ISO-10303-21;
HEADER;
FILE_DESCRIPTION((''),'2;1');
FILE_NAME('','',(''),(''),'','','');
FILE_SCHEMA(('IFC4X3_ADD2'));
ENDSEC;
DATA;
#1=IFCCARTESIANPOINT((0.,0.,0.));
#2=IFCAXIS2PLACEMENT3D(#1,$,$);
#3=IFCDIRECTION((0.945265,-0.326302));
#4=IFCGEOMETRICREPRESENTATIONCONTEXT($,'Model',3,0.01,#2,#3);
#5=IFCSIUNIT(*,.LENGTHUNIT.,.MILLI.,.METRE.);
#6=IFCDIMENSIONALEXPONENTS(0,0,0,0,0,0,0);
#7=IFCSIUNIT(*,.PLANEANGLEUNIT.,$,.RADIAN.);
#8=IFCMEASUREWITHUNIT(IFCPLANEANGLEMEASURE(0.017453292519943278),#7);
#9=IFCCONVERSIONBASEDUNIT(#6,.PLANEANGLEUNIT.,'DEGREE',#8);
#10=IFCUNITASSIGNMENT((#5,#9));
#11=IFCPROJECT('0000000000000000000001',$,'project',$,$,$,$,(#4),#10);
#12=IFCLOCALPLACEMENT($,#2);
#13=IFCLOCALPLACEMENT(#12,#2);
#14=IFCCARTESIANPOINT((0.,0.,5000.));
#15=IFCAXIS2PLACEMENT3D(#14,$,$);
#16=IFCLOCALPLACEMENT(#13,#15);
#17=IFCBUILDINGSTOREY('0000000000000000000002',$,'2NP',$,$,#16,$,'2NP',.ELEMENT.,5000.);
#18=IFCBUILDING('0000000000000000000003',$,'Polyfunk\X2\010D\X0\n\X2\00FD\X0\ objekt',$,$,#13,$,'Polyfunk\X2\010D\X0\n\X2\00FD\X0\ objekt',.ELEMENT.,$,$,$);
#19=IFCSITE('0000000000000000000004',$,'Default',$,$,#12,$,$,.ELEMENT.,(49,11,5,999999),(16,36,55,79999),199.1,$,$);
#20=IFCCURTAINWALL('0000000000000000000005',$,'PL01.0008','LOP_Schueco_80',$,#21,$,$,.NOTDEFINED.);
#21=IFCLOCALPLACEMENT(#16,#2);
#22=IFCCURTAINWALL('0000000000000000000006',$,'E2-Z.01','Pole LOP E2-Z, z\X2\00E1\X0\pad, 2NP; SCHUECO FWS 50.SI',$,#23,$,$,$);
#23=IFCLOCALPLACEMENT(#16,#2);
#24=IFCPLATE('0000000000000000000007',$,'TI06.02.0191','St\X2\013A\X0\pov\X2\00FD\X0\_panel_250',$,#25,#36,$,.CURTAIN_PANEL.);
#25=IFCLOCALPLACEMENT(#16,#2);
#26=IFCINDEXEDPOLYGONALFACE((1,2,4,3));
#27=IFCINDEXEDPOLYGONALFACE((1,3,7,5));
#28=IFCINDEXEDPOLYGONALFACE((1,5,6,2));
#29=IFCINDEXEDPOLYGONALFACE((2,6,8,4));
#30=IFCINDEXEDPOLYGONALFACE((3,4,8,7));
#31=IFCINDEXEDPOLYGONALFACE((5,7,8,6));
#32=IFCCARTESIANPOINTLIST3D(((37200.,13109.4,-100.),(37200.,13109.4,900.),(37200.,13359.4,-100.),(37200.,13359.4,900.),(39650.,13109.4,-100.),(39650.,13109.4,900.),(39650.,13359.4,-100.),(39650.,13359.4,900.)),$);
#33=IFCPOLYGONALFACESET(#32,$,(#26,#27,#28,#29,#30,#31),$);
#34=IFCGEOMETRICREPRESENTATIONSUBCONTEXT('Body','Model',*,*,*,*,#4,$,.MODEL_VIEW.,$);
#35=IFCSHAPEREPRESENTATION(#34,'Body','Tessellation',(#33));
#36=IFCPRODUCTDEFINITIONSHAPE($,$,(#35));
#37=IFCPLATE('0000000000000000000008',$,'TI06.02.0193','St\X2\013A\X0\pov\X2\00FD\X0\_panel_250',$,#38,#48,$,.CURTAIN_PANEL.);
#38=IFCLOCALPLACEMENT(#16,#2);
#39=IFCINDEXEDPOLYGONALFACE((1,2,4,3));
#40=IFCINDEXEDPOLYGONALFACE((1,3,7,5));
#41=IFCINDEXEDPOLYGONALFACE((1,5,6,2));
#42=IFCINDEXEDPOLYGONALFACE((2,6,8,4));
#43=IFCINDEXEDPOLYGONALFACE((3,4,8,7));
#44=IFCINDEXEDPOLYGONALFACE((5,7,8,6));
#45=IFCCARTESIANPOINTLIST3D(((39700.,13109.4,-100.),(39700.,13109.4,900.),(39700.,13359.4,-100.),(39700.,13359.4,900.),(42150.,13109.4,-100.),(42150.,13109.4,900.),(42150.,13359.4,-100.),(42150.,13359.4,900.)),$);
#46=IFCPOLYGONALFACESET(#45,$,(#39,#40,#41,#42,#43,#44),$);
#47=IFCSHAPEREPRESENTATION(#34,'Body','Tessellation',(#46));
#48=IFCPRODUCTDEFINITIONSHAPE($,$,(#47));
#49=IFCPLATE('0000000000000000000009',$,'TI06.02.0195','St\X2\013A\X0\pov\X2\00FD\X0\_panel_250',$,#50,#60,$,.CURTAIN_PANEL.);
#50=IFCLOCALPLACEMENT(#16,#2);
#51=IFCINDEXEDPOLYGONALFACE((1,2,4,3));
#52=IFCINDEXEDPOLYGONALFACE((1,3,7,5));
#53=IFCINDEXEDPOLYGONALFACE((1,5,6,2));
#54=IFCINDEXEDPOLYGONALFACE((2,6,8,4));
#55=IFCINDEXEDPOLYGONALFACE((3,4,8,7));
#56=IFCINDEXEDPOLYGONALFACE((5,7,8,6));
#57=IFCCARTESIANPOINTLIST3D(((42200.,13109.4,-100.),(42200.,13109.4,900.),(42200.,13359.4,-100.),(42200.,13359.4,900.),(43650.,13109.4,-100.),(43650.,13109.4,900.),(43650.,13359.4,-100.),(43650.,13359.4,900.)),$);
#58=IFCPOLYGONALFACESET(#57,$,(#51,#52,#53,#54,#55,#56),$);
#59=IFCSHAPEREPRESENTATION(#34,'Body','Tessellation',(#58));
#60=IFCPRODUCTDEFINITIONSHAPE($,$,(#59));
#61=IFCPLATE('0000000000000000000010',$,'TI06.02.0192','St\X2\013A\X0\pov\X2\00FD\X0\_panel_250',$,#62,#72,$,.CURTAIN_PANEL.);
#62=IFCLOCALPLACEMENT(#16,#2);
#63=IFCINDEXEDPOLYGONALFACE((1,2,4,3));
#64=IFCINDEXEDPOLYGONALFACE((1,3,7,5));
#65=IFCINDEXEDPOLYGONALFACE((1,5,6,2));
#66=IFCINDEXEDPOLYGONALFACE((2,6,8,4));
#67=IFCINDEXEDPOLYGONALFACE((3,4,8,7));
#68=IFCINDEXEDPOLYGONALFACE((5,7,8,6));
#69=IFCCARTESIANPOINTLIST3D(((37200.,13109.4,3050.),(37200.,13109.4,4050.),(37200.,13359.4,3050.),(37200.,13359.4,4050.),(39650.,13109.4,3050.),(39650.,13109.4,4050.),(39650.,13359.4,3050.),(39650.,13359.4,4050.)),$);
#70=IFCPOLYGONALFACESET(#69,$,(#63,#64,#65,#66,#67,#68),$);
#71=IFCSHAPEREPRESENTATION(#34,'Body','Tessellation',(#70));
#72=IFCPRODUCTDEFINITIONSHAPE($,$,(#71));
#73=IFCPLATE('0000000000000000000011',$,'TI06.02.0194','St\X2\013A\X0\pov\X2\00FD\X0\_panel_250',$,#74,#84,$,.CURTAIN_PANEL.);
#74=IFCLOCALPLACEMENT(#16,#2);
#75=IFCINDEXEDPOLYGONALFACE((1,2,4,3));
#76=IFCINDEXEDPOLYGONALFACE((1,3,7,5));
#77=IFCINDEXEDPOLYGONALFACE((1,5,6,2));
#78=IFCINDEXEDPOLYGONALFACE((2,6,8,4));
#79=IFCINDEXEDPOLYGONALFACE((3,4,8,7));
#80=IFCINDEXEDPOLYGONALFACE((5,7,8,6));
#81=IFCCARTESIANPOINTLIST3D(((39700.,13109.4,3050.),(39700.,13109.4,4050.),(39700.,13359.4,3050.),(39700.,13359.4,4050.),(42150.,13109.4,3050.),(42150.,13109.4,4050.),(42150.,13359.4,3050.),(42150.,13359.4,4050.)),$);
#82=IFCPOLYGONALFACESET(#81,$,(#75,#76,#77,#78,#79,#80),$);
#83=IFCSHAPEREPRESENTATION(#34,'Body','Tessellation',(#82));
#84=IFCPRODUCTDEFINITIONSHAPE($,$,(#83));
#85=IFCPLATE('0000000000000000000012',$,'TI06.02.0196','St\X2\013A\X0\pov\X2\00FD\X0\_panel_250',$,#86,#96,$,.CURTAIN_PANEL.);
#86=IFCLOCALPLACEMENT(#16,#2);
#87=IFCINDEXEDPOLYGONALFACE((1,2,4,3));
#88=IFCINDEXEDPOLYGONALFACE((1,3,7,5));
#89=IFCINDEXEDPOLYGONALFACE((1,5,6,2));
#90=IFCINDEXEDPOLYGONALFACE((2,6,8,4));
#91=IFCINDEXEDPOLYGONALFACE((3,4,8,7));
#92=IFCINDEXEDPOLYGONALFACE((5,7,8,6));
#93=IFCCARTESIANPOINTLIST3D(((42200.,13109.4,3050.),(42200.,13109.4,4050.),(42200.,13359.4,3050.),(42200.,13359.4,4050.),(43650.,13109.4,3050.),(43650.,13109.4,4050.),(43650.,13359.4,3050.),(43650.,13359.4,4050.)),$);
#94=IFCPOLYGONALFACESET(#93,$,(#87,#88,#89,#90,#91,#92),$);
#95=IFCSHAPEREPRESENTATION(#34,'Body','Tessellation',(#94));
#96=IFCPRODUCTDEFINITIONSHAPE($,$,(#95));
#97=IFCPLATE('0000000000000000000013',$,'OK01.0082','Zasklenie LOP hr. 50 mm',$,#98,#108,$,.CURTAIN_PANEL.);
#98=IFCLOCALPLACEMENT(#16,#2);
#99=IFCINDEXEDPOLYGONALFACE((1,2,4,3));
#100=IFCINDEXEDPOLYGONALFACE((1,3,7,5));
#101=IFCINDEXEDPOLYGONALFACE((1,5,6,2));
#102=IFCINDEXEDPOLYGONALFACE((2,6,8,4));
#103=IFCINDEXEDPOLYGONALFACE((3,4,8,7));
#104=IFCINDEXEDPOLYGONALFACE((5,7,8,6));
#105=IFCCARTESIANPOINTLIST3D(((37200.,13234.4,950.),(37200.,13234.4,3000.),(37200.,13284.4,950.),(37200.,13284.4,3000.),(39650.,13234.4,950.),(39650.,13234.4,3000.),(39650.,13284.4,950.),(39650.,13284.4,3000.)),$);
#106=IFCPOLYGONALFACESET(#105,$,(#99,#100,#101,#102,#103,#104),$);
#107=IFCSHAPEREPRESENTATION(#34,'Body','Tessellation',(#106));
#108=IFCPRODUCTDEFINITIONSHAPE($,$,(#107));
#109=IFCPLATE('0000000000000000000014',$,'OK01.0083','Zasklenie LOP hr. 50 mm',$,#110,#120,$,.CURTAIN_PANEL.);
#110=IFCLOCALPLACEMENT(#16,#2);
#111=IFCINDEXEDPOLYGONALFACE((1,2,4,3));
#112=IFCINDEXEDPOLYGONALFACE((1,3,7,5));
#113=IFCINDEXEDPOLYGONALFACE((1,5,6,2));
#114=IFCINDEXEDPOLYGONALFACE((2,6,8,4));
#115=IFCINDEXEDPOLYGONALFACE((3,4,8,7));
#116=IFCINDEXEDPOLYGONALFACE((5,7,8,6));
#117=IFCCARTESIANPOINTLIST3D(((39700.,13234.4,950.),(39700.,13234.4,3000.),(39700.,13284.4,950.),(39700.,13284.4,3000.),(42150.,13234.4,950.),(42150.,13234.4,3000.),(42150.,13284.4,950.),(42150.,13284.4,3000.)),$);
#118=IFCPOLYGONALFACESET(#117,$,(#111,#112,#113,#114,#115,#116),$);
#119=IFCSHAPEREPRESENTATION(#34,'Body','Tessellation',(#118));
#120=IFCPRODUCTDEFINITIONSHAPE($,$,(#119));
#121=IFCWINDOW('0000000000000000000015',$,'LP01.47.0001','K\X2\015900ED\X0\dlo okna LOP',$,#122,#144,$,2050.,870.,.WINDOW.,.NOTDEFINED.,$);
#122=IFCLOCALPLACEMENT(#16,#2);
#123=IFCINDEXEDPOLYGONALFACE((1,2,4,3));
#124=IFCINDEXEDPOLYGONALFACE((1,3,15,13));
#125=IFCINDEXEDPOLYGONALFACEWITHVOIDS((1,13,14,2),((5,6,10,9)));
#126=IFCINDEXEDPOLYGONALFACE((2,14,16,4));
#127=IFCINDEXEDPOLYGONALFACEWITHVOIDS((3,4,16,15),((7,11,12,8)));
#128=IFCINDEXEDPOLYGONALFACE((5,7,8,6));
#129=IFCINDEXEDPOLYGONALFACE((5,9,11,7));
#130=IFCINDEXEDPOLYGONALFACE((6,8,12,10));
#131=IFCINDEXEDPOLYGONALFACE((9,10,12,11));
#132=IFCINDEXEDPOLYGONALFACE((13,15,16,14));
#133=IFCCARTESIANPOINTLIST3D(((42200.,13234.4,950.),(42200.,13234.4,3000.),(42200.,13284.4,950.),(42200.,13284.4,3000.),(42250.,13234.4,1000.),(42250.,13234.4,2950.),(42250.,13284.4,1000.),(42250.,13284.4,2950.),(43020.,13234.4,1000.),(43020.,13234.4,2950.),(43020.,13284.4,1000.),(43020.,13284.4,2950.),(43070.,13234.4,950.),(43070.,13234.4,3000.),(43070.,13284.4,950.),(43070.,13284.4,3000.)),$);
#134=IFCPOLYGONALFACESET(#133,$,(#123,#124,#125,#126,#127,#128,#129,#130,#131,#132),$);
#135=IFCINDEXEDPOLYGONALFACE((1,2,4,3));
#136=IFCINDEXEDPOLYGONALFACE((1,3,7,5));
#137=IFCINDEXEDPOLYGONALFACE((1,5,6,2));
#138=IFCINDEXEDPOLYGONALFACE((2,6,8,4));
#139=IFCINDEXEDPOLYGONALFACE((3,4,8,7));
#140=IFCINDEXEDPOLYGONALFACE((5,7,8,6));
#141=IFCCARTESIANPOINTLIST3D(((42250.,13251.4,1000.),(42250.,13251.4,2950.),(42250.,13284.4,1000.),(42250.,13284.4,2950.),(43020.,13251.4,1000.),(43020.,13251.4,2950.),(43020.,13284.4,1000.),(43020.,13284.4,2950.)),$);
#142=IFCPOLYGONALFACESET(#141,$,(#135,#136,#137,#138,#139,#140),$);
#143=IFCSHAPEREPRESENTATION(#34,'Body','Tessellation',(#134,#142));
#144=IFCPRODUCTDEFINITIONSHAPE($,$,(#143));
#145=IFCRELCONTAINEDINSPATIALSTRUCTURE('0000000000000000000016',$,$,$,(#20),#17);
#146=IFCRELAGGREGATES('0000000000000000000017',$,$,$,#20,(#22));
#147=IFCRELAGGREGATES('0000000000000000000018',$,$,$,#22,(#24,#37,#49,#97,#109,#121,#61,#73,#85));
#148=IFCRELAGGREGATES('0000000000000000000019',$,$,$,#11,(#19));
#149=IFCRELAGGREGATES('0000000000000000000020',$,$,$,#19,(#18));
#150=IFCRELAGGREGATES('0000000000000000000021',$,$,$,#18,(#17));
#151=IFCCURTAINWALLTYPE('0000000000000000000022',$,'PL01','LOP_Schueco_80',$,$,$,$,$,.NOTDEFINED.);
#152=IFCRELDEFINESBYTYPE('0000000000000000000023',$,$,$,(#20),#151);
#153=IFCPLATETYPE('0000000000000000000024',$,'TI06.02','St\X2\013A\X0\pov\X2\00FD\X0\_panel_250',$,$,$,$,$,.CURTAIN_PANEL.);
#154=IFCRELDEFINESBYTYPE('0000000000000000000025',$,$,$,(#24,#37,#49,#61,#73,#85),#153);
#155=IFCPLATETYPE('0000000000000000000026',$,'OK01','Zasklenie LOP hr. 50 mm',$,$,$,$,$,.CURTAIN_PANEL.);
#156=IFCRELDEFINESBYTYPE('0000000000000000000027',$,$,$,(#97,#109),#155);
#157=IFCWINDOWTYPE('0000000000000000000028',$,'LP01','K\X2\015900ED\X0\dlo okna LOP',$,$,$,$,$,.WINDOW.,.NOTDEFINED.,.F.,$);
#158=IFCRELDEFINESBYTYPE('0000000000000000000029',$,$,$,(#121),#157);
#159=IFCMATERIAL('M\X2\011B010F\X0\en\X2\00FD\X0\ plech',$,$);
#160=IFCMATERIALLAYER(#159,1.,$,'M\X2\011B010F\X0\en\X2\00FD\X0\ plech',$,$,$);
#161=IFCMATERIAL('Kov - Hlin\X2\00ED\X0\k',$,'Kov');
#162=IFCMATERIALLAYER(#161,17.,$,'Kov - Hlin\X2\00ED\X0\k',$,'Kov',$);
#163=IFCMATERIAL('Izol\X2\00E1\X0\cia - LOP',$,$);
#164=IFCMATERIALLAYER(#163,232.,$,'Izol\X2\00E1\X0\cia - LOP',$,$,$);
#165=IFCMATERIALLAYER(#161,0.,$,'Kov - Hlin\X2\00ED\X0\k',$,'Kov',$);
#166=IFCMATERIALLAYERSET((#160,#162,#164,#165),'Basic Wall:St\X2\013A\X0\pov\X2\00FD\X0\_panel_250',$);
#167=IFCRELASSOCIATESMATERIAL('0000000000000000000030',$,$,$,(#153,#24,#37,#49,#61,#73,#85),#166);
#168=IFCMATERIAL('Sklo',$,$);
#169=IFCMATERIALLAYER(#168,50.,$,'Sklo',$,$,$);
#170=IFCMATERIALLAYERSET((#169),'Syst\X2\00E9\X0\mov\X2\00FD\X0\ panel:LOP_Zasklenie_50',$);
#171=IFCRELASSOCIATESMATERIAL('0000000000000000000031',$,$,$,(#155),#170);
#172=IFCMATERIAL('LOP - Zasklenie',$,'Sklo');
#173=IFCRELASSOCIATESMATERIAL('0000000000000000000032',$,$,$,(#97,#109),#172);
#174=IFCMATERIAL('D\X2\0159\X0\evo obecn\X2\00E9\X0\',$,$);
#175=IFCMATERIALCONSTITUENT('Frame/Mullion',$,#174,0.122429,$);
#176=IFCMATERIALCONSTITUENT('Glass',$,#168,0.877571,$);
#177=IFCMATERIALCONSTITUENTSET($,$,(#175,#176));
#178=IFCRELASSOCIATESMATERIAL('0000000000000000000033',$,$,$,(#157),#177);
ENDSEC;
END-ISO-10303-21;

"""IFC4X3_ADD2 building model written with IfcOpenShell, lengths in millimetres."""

from ifc_helpers import new_model, entity, si_unit, converted_unit, direction, frame, frame_2d, origin, origin_2d_with_axis, place, context, subcontext, project, spatial, polyline, rectangle, outline, extrude, source, transform, mapped, material, layer, layer_set, layer_usage, constituent, constituent_set, type_object, type_shapes, element, aggregate, save


model = new_model("IFC4X3_ADD2")

# Units and contexts
model_context = context("Model", 3, precision=0.01, world=origin(), true_north=direction((0.945265, -0.326302)))
body_context = subcontext(model_context, "Body", "Model", "MODEL_VIEW")
ifc_project = project(units=[si_unit("LENGTHUNIT", "METRE", prefix="MILLI"), converted_unit("PLANEANGLEUNIT", "DEGREE", entity("IfcPlaneAngleMeasure", 0.017453292519943278), si_unit("PLANEANGLEUNIT", "RADIAN"), dimensions=[0, 0, 0, 0, 0, 0, 0])], contexts=[model_context])

# Site, building, storey
site_placement = place(None, origin())
site = spatial("IfcSite", under=ifc_project, at=site_placement, Name="Default", CompositionType="ELEMENT", RefLatitude=(49, 11, 5, 999999), RefLongitude=(16, 36, 55, 79999), RefElevation=199.1)
building_placement = place(site_placement, origin())
building = spatial("IfcBuilding", under=site, at=building_placement, Name="Polyfunkčný objekt", LongName="Polyfunkčný objekt", CompositionType="ELEMENT")
storey_placement = place(building_placement, frame((0.0, 0.0, 5000.0)))
storey = spatial("IfcBuildingStorey", under=building, at=storey_placement, Name="2NP", LongName="2NP", CompositionType="ELEMENT", Elevation=5000.0)

# Curtain walls, plates, window
curtain_wall_type = type_object("IfcCurtainWallType", Name="PL01", Description="LOP_Schueco_80", PredefinedType="NOTDEFINED")
curtain_wall_1_placement = place(storey_placement, frame((0.0, 0.0, -5000.0)))
curtain_wall_1 = element("IfcCurtainWall", 1, at=curtain_wall_1_placement, inside=storey, type_object=curtain_wall_type, Name="PL01.0008", Description="LOP_Schueco_80", PredefinedType="NOTDEFINED")
curtain_wall_2 = element("IfcCurtainWall", 2, Name="E2-Z.01", Description="Pole LOP E2-Z, západ, 2NP; SCHUECO FWS 50.SI")
aggregate(curtain_wall_1, [curtain_wall_2])
ifc_material_1 = material(Name="Měďený plech")
ifc_layer_1 = layer(ifc_material_1, 1.0, Name="Měďený plech")
ifc_material_2 = material(Name="Kov - Hliník", Category="Kov")
ifc_layer_2 = layer(ifc_material_2, 17.0, Name="Kov - Hliník", Category="Kov")
ifc_material_3 = material(Name="Izolácia - LOP")
ifc_layer_3 = layer(ifc_material_3, 232.0, Name="Izolácia - LOP")
ifc_layer_4 = layer(ifc_material_2, 0.0, Name="Kov - Hliník", Category="Kov")
ifc_layer_set_1 = layer_set([ifc_layer_1, ifc_layer_2, ifc_layer_3, ifc_layer_4], Name="Basic Wall:Stĺpový_panel_250")
ifc_layer_usage_1 = layer_usage(ifc_layer_set_1, "AXIS2", "NEGATIVE", 125.0)
plate_type_1 = type_object("IfcPlateType", Name="TI06.02", Description="Stĺpový_panel_250", PredefinedType="CURTAIN_PANEL", material=ifc_layer_set_1)
plate_1_placement = place(storey_placement, frame((37200.0, 13234.4, -100.0)))
plate_1 = element("IfcPlate", 3, at=plate_1_placement, type_object=plate_type_1, material=ifc_layer_usage_1, Name="TI06.02.0191", Description="Stĺpový_panel_250", PredefinedType="CURTAIN_PANEL", context=body_context, shape_type="SweptSolid", body=[
    extrude(rectangle(XDim=250.0, YDim=2450.0, at=frame_2d((0.0, 0.0), x_axis=(1.0, 0.0))), frame((1225.0, 0.0, 0.0), z_axis=(0.0, 0.0, 1.0), x_axis=(0.0, 1.0, 0.0)), (0.0, 0.0, 1.0), 1000.0),
])
ifc_layer_usage_2 = layer_usage(ifc_layer_set_1, "AXIS2", "NEGATIVE", 125.0)
plate_2_placement = place(storey_placement, frame((39700.0, 13234.4, -100.0)))
plate_2 = element("IfcPlate", 4, at=plate_2_placement, type_object=plate_type_1, material=ifc_layer_usage_2, Name="TI06.02.0193", Description="Stĺpový_panel_250", PredefinedType="CURTAIN_PANEL", context=body_context, shape_type="SweptSolid", body=[
    extrude(rectangle(XDim=250.0, YDim=2450.0, at=frame_2d((0.0, 0.0), x_axis=(1.0, 0.0))), frame((1225.0, 0.0, 0.0), z_axis=(0.0, 0.0, 1.0), x_axis=(0.0, 1.0, 0.0)), (0.0, 0.0, 1.0), 1000.0),
])
ifc_layer_usage_3 = layer_usage(ifc_layer_set_1, "AXIS2", "NEGATIVE", 125.0)
plate_3_placement = place(storey_placement, frame((42200.0, 13234.4, -100.0)))
plate_3 = element("IfcPlate", 5, at=plate_3_placement, type_object=plate_type_1, material=ifc_layer_usage_3, Name="TI06.02.0195", Description="Stĺpový_panel_250", PredefinedType="CURTAIN_PANEL", context=body_context, shape_type="SweptSolid", body=[
    extrude(rectangle(XDim=250.0, YDim=1450.0, at=frame_2d((0.0, 0.0), x_axis=(1.0, 0.0))), frame((725.0, 0.0, 0.0), z_axis=(0.0, 0.0, 1.0), x_axis=(0.0, 1.0, 0.0)), (0.0, 0.0, 1.0), 1000.0),
])
ifc_layer_usage_4 = layer_usage(ifc_layer_set_1, "AXIS2", "NEGATIVE", 125.0)
plate_4_placement = place(storey_placement, frame((37200.0, 13234.4, 3050.0)))
plate_4 = element("IfcPlate", 6, at=plate_4_placement, type_object=plate_type_1, material=ifc_layer_usage_4, Name="TI06.02.0192", Description="Stĺpový_panel_250", PredefinedType="CURTAIN_PANEL", context=body_context, shape_type="SweptSolid", body=[
    extrude(rectangle(XDim=250.0, YDim=2450.0, at=frame_2d((0.0, 0.0), x_axis=(1.0, 0.0))), frame((1225.0, 0.0, 0.0), z_axis=(0.0, 0.0, 1.0), x_axis=(0.0, 1.0, 0.0)), (0.0, 0.0, 1.0), 1000.0),
])
ifc_layer_usage_5 = layer_usage(ifc_layer_set_1, "AXIS2", "NEGATIVE", 125.0)
plate_5_placement = place(storey_placement, frame((39700.0, 13234.4, 3050.0)))
plate_5 = element("IfcPlate", 7, at=plate_5_placement, type_object=plate_type_1, material=ifc_layer_usage_5, Name="TI06.02.0194", Description="Stĺpový_panel_250", PredefinedType="CURTAIN_PANEL", context=body_context, shape_type="SweptSolid", body=[
    extrude(rectangle(XDim=250.0, YDim=2450.0, at=frame_2d((0.0, 0.0), x_axis=(1.0, 0.0))), frame((1225.0, 0.0, 0.0), z_axis=(0.0, 0.0, 1.0), x_axis=(0.0, 1.0, 0.0)), (0.0, 0.0, 1.0), 1000.0),
])
ifc_layer_usage_6 = layer_usage(ifc_layer_set_1, "AXIS2", "NEGATIVE", 125.0)
plate_6_placement = place(storey_placement, frame((42200.0, 13234.4, 3050.0)))
plate_6 = element("IfcPlate", 8, at=plate_6_placement, type_object=plate_type_1, material=ifc_layer_usage_6, Name="TI06.02.0196", Description="Stĺpový_panel_250", PredefinedType="CURTAIN_PANEL", context=body_context, shape_type="SweptSolid", body=[
    extrude(rectangle(XDim=250.0, YDim=1450.0, at=frame_2d((0.0, 0.0), x_axis=(1.0, 0.0))), frame((725.0, 0.0, 0.0), z_axis=(0.0, 0.0, 1.0), x_axis=(0.0, 1.0, 0.0)), (0.0, 0.0, 1.0), 1000.0),
])
ifc_material_4 = material(Name="LOP - Zasklenie", Category="Sklo")
ifc_material_5 = material(Name="Sklo")
ifc_layer_5 = layer(ifc_material_5, 50.0, Name="Sklo")
ifc_layer_set_2 = layer_set([ifc_layer_5], Name="Systémový panel:LOP_Zasklenie_50")
plate_type_2 = type_object("IfcPlateType", Name="OK01", Description="Zasklenie LOP hr. 50 mm", PredefinedType="CURTAIN_PANEL", material=ifc_layer_set_2)
shared_shape_1 = source(origin(), body_context, "Body", "SweptSolid", [
    extrude(rectangle(XDim=50.0, YDim=2450.0, at=origin_2d_with_axis()), frame((0.0, 25.0, 0.0), z_axis=(0.0, 0.0, 1.0), x_axis=(0.0, 1.0, 0.0)), (0.0, 0.0, 1.0), 2050.0),
])
type_shapes(plate_type_2, [shared_shape_1])
plate_7_placement = place(curtain_wall_1_placement, frame((38425.0, 13234.4, 5950.0)))
plate_7 = element("IfcPlate", 9, at=plate_7_placement, type_object=plate_type_2, material=ifc_material_4, Name="OK01.0082", Description="Zasklenie LOP hr. 50 mm", PredefinedType="CURTAIN_PANEL", context=body_context, shape_type="MappedRepresentation", body=[
    mapped(shared_shape_1, transform((0.0, 0.0, 0.0), scale=1.0)),
])
plate_8_placement = place(curtain_wall_1_placement, frame((40925.0, 13234.4, 5950.0)))
plate_8 = element("IfcPlate", 10, at=plate_8_placement, type_object=plate_type_2, material=ifc_material_4, Name="OK01.0083", Description="Zasklenie LOP hr. 50 mm", PredefinedType="CURTAIN_PANEL", context=body_context, shape_type="MappedRepresentation", body=[
    mapped(shared_shape_1, transform((0.0, 0.0, 0.0), scale=1.0)),
])
ifc_material_6 = material(Name="Dřevo obecné")
ifc_constituent_1 = constituent(ifc_material_6, Name="Frame/Mullion", fraction=0.122429)
ifc_constituent_2 = constituent(ifc_material_5, Name="Glass", fraction=0.877571)
ifc_constituent_set = constituent_set(constituents=[ifc_constituent_1, ifc_constituent_2])
window_type = type_object("IfcWindowType", Name="LP01", Description="Křídlo okna LOP", ParameterTakesPrecedence=False, PartitioningType="NOTDEFINED", PredefinedType="WINDOW", material=ifc_constituent_set)
shared_shape_2 = source(origin(), body_context, "Body", "SweptSolid", [
    extrude(outline(polyline([(-1025.0, -435.0), (1025.0, -435.0), (1025.0, 435.0), (-1025.0, 435.0), (-1025.0, -435.0)]), holes=[polyline([(-975.0, -385.0), (-975.0, 385.0), (975.0, 385.0), (975.0, -385.0), (-975.0, -385.0)])]), frame((0.0, 0.0, 1025.0), z_axis=(0.0, 1.0, 0.0), x_axis=(0.0, 0.0, -1.0)), (0.0, 0.0, 1.0), 50.0),
    extrude(rectangle(XDim=33.0, YDim=770.0, at=origin_2d_with_axis()), frame((0.0, 33.5, 50.0), z_axis=(0.0, 0.0, 1.0), x_axis=(0.0, -1.0, 0.0)), (0.0, 0.0, 1.0), 1950.0),
])
type_shapes(window_type, [shared_shape_2])
window_placement = place(curtain_wall_1_placement, frame((42635.0, 13234.4, 5950.0)))
window = element("IfcWindow", 11, at=window_placement, type_object=window_type, Name="LP01.47.0001", Description="Křídlo okna LOP", OverallHeight=2050.0, OverallWidth=870.0, PartitioningType="NOTDEFINED", PredefinedType="WINDOW", context=body_context, shape_type="MappedRepresentation", body=[
    mapped(shared_shape_2, transform((0.0, 0.0, 0.0), scale=1.0)),
])
aggregate(curtain_wall_2, [plate_1, plate_2, plate_3, plate_7, plate_8, window, plate_4, plate_5, plate_6])

save(model, "model.ifc")
